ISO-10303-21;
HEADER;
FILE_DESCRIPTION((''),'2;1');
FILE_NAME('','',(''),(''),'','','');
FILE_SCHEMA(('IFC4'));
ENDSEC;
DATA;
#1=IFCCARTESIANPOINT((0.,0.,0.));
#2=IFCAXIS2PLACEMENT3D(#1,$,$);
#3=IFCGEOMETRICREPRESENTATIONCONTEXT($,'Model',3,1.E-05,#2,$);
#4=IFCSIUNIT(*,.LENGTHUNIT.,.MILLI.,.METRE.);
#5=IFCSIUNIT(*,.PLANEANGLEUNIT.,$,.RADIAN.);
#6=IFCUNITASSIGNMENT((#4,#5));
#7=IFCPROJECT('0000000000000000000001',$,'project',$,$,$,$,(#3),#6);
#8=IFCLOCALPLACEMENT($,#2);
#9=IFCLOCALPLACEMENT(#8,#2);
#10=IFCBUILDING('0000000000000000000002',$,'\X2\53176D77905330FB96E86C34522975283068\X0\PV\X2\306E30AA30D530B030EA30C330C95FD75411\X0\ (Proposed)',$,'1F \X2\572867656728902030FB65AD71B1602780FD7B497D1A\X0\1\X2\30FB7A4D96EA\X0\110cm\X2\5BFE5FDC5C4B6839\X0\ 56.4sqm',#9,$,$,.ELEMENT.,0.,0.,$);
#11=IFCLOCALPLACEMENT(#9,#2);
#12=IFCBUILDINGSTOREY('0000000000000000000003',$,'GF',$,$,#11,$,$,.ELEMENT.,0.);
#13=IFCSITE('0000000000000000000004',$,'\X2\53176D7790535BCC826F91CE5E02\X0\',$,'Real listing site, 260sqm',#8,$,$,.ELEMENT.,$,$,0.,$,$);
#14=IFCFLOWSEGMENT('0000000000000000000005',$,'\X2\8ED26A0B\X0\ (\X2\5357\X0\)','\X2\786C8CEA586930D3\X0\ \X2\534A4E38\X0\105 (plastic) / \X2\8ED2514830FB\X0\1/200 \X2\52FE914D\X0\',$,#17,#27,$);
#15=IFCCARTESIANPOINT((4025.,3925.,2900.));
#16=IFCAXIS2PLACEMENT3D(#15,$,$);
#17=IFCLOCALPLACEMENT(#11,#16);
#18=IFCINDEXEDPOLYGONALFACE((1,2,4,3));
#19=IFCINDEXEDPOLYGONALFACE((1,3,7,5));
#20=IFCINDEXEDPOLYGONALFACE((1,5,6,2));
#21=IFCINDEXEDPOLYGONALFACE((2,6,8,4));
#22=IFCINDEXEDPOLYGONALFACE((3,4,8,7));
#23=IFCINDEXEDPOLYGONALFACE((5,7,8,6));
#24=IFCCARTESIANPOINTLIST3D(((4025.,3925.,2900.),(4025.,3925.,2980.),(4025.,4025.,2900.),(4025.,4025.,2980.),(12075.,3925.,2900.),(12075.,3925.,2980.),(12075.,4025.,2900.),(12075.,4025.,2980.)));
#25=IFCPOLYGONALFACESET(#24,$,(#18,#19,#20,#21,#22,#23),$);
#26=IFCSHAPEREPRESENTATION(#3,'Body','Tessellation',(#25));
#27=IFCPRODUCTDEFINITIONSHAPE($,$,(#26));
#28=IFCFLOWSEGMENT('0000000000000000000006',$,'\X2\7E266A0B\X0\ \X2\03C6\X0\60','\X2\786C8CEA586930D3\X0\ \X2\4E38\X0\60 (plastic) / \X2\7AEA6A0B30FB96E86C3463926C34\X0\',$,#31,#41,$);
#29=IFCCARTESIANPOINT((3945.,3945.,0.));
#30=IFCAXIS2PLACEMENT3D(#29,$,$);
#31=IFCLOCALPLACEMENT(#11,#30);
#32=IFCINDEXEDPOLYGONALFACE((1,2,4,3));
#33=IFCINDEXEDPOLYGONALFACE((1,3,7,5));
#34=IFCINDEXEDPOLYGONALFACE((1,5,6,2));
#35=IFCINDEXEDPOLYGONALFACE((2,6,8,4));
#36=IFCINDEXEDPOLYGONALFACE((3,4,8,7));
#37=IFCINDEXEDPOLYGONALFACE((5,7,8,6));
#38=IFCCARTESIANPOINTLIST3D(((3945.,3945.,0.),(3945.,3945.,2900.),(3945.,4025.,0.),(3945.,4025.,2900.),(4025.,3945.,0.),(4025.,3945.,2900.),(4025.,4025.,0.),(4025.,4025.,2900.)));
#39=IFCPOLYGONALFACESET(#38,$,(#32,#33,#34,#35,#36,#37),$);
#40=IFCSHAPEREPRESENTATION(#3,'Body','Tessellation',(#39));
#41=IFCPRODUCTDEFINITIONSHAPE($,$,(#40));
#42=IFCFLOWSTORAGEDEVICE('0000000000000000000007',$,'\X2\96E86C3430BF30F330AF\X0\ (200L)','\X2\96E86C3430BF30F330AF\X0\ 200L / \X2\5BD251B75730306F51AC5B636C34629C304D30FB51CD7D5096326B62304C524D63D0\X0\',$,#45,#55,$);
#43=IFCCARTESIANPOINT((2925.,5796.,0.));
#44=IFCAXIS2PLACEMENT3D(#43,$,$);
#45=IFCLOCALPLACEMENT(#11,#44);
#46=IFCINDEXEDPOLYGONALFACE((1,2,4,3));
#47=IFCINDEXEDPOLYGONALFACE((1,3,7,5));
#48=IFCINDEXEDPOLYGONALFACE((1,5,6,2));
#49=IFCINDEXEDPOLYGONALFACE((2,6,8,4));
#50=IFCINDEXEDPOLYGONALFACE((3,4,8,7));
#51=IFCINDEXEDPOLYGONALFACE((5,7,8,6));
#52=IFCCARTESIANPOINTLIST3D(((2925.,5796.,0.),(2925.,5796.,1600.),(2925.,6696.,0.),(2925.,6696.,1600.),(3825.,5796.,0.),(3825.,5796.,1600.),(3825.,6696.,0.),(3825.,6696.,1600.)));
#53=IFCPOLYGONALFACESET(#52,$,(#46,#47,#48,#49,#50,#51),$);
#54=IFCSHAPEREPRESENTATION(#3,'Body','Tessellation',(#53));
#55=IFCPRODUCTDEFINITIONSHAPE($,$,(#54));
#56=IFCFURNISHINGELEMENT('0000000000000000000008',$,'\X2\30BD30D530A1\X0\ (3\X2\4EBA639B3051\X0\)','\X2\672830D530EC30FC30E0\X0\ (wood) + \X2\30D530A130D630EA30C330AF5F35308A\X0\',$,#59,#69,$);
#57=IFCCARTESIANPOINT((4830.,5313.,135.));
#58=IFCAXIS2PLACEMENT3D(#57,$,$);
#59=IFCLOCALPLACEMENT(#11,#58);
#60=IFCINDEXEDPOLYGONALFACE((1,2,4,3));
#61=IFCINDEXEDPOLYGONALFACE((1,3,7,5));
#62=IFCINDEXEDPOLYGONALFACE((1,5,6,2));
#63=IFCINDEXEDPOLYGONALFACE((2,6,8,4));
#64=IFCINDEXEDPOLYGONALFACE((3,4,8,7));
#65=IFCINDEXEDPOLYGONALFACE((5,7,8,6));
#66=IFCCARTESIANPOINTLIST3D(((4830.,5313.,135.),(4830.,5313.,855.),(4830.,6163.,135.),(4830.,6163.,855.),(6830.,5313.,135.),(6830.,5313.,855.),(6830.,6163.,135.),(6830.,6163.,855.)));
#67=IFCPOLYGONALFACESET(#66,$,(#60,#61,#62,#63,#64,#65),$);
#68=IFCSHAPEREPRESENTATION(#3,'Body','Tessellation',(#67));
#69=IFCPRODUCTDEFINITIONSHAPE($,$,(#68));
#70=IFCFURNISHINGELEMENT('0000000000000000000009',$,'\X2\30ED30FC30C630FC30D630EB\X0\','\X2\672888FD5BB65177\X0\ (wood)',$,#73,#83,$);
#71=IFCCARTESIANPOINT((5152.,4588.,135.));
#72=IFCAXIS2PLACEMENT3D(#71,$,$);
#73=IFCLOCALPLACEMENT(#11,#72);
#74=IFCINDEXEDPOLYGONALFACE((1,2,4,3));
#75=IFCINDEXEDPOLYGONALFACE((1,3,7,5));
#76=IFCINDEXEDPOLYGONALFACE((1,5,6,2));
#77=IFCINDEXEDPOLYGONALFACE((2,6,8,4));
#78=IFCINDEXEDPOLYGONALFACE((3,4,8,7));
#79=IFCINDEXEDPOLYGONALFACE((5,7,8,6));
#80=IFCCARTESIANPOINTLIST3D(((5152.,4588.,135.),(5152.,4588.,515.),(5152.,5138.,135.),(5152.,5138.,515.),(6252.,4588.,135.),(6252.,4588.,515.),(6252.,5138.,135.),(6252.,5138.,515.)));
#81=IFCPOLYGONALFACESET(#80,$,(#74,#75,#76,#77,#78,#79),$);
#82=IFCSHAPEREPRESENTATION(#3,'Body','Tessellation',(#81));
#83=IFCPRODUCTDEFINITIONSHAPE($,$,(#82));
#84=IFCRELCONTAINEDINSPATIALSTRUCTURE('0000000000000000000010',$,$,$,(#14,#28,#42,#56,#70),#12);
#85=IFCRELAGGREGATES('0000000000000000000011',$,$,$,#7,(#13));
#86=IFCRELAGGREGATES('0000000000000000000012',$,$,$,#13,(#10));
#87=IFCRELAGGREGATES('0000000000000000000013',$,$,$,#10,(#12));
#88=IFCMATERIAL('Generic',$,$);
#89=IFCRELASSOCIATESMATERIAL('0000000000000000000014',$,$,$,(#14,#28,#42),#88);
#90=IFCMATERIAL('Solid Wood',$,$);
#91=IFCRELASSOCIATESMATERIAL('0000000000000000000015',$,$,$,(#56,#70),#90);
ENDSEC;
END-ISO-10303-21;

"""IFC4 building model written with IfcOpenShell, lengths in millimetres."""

from ifc_helpers import new_model, si_unit, frame, frame_2d, origin, place, context, project, spatial, rectangle, extrude, material, element, save


model = new_model("IFC4")

# Units and contexts
model_context = context("Model", 3, precision=1e-05, world=origin())
ifc_project = project(units=[si_unit("LENGTHUNIT", "METRE", prefix="MILLI"), si_unit("PLANEANGLEUNIT", "RADIAN")], contexts=[model_context])

# Site, building, storey
site_placement = place(None, origin())
site = spatial("IfcSite", under=ifc_project, at=site_placement, Name="北海道富良野市", ObjectType="Real listing site, 260sqm", CompositionType="ELEMENT", RefElevation=0.0)
building_placement = place(site_placement, origin())
building = spatial("IfcBuilding", under=site, at=building_placement, Name="北海道・雨水利用とPVのオフグリッド志向 (Proposed)", ObjectType="1F 在来木造・断熱性能等級1・積雪110cm対応屋根 56.4sqm", CompositionType="ELEMENT", ElevationOfRefHeight=0.0, ElevationOfTerrain=0.0)
storey_placement = place(building_placement, origin())
storey = spatial("IfcBuildingStorey", under=building, at=storey_placement, Name="GF", CompositionType="ELEMENT", Elevation=0.0)

# Shared definitions
ifc_material_1 = material(Name="Solid Wood")

# Shared definitions
ifc_material_2 = material(Name="Generic")

# Flow segments
flow_segment_1_placement = place(storey_placement, frame((4025.0, 3925.0, 2900.0)))
element("IfcFlowSegment", 1, at=flow_segment_1_placement, inside=storey, material=ifc_material_2, Name="軒樋 (南)", Description="硬質塩ビ 半丸105 (plastic) / 軒先・1/200 勾配", context=model_context, shape_type="SweptSolid", body=[
    extrude(rectangle(XDim=8050.0, YDim=100.0, at=frame_2d((4025.0, 50.0))), frame((4025.0, 3925.0, 2900.0)), (0.0, 0.0, 1.0), 80.0),
])
flow_segment_2_placement = place(storey_placement, frame((3945.0, 3945.0, 0.0)))
element("IfcFlowSegment", 2, at=flow_segment_2_placement, inside=storey, material=ifc_material_2, Name="縦樋 φ60", Description="硬質塩ビ 丸60 (plastic) / 竪樋・雨水排水", context=model_context, shape_type="SweptSolid", body=[
    extrude(rectangle(XDim=80.0, YDim=80.0, at=frame_2d((40.0, 40.0))), frame((3945.0, 3945.0, 0.0)), (0.0, 0.0, 1.0), 2900.0),
])

# Flow storage device
flow_storage_device_placement = place(storey_placement, frame((2925.0, 5796.0, 0.0)))
element("IfcFlowStorageDevice", 3, at=flow_storage_device_placement, inside=storey, material=ifc_material_2, Name="雨水タンク (200L)", Description="雨水タンク 200L / 寒冷地は冬季水抜き・凍結防止が前提", context=model_context, shape_type="SweptSolid", body=[
    extrude(rectangle(XDim=900.0, YDim=900.0, at=frame_2d((450.0, 450.0))), frame((2925.0, 5796.0, 0.0)), (0.0, 0.0, 1.0), 1600.0),
])

# Furnishing elements
furnishing_1_placement = place(storey_placement, frame((4830.0, 5313.0, 135.0)))
element("IfcFurnishingElement", 4, at=furnishing_1_placement, inside=storey, material=ifc_material_1, Name="ソファ (3人掛け)", Description="木フレーム (wood) + ファブリック張り", context=model_context, shape_type="SweptSolid", body=[
    extrude(rectangle(XDim=2000.0, YDim=850.0, at=frame_2d((1000.0, 425.0))), frame((4830.0, 5313.0, 135.0)), (0.0, 0.0, 1.0), 720.0),
])
furnishing_2_placement = place(storey_placement, frame((5152.0, 4588.0, 135.0)))
element("IfcFurnishingElement", 5, at=furnishing_2_placement, inside=storey, material=ifc_material_1, Name="ローテーブル", Description="木製家具 (wood)", context=model_context, shape_type="SweptSolid", body=[
    extrude(rectangle(XDim=1100.0, YDim=550.0, at=frame_2d((550.0, 275.0))), frame((5152.0, 4588.0, 135.0)), (0.0, 0.0, 1.0), 380.0),
])

save(model, "model.ifc")
